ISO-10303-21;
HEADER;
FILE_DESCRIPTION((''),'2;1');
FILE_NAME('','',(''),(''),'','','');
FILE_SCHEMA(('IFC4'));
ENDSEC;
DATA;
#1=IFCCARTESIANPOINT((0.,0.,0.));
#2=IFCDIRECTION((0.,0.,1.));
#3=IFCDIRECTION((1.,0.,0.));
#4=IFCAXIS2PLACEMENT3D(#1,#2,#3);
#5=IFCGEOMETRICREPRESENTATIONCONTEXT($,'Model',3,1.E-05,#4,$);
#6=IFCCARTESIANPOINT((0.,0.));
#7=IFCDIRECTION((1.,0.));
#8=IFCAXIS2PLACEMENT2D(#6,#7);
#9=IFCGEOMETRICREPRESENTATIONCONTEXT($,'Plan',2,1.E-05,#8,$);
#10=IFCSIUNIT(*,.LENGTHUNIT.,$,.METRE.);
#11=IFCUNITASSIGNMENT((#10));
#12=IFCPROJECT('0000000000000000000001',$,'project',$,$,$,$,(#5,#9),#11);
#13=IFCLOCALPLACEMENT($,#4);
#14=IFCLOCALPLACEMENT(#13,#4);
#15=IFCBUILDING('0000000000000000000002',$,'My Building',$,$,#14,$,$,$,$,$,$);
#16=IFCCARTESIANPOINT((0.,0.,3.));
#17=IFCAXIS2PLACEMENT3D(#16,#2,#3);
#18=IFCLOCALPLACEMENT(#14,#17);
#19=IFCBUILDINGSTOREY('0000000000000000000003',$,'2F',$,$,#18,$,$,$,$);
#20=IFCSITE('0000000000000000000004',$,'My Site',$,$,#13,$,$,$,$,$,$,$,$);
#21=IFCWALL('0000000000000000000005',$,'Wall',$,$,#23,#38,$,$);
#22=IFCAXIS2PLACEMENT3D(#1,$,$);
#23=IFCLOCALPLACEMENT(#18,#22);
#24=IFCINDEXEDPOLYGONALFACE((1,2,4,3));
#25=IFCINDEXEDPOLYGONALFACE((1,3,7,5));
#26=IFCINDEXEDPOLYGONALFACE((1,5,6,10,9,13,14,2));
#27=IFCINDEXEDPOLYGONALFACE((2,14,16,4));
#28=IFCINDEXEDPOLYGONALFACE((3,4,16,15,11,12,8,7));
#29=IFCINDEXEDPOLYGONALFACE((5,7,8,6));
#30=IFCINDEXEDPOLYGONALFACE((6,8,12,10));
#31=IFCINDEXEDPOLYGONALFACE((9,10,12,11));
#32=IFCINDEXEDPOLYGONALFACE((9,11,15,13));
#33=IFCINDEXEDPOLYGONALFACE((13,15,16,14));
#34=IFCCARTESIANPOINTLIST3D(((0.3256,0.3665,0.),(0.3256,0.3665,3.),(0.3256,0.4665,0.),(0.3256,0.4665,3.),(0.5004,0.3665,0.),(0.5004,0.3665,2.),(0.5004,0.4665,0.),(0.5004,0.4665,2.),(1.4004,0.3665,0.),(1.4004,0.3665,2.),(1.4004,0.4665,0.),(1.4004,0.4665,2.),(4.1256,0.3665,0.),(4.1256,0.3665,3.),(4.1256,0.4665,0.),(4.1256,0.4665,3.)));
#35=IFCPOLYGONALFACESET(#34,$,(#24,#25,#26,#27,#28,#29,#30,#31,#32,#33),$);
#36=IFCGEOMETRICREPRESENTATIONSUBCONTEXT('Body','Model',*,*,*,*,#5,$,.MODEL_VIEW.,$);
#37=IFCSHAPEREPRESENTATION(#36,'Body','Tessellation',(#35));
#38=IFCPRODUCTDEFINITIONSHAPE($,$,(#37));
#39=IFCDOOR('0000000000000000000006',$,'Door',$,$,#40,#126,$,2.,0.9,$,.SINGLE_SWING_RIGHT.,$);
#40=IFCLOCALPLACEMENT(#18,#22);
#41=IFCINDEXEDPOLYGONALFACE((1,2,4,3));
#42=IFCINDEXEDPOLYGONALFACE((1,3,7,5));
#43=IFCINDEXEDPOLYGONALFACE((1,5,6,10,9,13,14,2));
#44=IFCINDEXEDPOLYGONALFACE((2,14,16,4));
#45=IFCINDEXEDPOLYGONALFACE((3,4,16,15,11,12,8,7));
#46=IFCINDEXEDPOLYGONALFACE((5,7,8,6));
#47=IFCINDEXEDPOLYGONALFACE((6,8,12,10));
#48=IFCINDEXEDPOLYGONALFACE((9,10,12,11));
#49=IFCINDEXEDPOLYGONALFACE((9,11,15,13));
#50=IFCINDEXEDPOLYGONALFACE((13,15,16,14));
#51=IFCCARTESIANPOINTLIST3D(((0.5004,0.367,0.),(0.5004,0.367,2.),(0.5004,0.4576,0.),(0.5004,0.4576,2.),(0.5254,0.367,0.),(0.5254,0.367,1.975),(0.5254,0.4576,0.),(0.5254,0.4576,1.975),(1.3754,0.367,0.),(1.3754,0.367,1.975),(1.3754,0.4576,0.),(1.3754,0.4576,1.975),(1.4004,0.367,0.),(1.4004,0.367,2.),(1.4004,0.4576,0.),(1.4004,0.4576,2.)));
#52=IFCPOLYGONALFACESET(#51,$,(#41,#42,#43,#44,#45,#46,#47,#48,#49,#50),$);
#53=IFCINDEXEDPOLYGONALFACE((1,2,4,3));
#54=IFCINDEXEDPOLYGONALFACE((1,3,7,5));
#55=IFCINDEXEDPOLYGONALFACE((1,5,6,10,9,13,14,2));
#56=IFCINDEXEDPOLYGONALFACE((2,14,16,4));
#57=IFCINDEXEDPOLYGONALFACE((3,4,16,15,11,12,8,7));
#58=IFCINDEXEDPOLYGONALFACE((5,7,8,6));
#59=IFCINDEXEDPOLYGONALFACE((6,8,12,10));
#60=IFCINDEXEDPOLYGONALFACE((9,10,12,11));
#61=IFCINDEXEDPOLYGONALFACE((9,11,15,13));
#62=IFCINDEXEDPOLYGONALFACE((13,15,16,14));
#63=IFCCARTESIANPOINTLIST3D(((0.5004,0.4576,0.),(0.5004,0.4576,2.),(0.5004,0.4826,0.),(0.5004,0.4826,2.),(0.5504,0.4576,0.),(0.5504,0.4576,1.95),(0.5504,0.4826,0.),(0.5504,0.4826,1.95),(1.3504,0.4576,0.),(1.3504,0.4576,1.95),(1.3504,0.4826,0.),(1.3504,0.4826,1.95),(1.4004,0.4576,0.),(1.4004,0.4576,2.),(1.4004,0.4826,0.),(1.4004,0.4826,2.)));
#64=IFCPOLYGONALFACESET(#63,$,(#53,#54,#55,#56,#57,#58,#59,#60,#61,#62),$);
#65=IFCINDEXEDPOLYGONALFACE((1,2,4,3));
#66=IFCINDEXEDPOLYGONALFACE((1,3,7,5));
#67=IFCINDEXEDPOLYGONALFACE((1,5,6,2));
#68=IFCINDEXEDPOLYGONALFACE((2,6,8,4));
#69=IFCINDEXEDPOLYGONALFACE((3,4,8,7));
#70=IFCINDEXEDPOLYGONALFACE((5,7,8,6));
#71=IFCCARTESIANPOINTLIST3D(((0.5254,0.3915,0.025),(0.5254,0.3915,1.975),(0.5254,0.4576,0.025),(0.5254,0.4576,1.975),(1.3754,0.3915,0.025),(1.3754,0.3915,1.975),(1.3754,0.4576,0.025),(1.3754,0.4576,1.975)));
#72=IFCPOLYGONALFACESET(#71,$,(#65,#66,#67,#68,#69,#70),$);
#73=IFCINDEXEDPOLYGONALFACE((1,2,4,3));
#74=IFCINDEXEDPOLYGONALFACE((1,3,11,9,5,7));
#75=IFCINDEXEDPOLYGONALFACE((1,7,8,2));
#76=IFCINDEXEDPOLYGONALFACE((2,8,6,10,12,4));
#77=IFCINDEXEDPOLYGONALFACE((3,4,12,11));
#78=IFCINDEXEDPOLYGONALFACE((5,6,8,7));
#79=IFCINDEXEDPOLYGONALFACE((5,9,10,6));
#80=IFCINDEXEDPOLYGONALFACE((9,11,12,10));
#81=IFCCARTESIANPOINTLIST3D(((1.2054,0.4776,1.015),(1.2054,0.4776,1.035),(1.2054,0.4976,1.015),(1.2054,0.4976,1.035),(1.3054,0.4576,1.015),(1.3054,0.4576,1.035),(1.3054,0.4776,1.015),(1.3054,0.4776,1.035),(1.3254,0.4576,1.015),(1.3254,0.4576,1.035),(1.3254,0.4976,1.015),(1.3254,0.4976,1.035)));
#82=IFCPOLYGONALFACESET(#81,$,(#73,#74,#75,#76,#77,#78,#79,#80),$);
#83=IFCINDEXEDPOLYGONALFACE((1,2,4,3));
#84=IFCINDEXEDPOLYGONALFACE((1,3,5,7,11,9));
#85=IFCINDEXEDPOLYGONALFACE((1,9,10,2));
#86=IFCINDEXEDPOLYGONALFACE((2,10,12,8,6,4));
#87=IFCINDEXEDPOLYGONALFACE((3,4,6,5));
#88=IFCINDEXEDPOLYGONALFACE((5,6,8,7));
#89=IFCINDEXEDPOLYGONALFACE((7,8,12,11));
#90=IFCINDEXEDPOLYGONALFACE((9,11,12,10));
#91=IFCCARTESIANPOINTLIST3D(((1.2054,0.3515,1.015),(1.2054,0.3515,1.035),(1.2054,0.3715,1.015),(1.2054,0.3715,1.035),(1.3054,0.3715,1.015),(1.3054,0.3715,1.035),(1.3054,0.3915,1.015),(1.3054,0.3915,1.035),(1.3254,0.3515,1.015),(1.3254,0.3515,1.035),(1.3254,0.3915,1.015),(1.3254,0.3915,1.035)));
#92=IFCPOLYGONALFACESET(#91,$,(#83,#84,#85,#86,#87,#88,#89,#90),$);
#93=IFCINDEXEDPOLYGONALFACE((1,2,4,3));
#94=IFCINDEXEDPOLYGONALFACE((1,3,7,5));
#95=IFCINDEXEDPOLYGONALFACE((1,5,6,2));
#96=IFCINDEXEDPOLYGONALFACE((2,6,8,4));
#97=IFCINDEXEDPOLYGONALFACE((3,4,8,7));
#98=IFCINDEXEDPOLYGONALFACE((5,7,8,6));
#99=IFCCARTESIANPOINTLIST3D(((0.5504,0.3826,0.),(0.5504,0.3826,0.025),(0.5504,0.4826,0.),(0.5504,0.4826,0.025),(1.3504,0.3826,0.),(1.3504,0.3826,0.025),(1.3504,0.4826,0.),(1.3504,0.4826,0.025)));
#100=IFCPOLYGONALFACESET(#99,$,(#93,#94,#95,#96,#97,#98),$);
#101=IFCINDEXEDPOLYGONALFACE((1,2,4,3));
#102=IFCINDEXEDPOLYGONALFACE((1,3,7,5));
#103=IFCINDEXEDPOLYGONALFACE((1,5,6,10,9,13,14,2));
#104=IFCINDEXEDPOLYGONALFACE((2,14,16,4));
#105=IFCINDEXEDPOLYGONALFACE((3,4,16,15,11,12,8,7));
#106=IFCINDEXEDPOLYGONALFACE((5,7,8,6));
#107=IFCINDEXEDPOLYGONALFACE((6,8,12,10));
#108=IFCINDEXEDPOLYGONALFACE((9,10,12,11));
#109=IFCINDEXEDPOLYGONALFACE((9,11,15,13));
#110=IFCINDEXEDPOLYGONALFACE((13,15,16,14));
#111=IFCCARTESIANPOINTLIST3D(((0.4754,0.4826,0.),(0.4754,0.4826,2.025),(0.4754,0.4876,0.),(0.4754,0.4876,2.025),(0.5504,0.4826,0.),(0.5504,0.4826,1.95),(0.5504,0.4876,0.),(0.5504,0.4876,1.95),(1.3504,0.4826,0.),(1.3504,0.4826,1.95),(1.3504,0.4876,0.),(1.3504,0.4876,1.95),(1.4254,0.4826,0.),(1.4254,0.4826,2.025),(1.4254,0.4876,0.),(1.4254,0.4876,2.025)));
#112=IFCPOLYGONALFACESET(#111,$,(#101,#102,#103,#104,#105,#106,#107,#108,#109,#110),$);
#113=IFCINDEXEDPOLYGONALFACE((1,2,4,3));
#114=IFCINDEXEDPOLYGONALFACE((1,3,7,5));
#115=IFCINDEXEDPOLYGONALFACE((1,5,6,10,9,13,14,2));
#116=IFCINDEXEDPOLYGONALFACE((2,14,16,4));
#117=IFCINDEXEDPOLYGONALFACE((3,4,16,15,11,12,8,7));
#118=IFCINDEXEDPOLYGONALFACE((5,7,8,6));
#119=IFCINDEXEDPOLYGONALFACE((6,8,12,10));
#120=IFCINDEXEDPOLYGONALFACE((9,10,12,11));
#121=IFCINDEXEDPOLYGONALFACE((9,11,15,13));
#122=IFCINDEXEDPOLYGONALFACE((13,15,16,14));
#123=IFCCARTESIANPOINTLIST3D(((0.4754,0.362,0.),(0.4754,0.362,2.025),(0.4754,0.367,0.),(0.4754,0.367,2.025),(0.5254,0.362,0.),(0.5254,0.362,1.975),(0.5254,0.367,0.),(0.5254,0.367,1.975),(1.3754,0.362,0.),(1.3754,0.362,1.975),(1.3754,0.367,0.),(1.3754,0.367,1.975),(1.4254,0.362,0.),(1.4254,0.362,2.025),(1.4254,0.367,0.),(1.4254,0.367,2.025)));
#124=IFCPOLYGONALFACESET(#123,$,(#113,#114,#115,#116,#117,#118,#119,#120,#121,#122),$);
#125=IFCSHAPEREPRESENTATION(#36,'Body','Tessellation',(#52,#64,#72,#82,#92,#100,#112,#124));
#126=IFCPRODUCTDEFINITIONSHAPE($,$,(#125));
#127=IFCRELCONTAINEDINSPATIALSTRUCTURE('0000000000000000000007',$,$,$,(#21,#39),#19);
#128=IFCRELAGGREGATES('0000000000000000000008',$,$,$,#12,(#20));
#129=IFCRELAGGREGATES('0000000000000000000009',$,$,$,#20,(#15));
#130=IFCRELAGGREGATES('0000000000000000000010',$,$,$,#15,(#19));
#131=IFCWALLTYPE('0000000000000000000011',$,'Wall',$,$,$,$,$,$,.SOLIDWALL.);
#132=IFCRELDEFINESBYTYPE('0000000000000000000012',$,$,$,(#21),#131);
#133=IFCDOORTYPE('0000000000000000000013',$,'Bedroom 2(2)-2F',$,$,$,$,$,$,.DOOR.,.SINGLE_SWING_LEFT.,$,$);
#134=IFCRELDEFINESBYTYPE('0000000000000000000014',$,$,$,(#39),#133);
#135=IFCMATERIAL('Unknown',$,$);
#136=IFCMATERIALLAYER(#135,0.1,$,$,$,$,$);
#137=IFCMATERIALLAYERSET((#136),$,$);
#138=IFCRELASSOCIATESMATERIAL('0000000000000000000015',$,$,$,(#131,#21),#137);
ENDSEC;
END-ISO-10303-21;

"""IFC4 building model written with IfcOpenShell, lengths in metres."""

from ifc_helpers import new_model, entity, si_unit, frame, origin_with_axes, origin_2d_with_axis, place, context, subcontext, project, spatial, line, indexed_curve, outline, extrude, shape, source, transform, mapped, material, layer, layer_set, layer_usage, type_object, type_shapes, element, fill, save


model = new_model("IFC4")

# Units and contexts
model_context = context("Model", 3, precision=1e-05, world=origin_with_axes())
plan_context = context("Plan", 2, precision=1e-05, world=origin_2d_with_axis())
body_context_1 = subcontext(model_context, "Body", "Model", "MODEL_VIEW")
body_context_2 = subcontext(plan_context, "Body", "Plan", "PLAN_VIEW")
ifc_project = project(units=[si_unit("LENGTHUNIT", "METRE")], contexts=[model_context, plan_context])

# Site, building, storey
site_placement = place(None, origin_with_axes())
site = spatial("IfcSite", under=ifc_project, at=site_placement, Name="My Site")
building_placement = place(site_placement, origin_with_axes())
building = spatial("IfcBuilding", under=site, at=building_placement, Name="My Building")
storey_placement = place(building_placement, frame((0.0, 0.0, 3.0), z_axis=(0.0, 0.0, 1.0), x_axis=(1.0, 0.0, 0.0)))
storey = spatial("IfcBuildingStorey", under=building, at=storey_placement, Name="2F")

# Shared definitions
ifc_material = material(Name="Unknown")

# Shared definitions
ifc_layer = layer(ifc_material, 0.1)
ifc_layer_set = layer_set([ifc_layer])
wall_type = type_object("IfcWallType", Name="Wall", PredefinedType="SOLIDWALL", material=ifc_layer_set)

# Wall, opening, door
ifc_layer_usage_1 = layer_usage(ifc_layer_set, "AXIS2", "POSITIVE", 0.0)
wall_1_placement = place(storey_placement, frame((4.1256, 0.4665, 0.0), z_axis=(0.0, 0.0, 1.0), x_axis=(-1.0, 0.0, 0.0)))
wall_1 = element("IfcWall", 1, at=wall_1_placement, inside=storey, type_object=wall_type, material=ifc_layer_usage_1, Name="Wall", context=body_context_1, shape_type="SweptSolid", body=[
    extrude(outline(indexed_curve([(0.0, 0.0), (0.0, 0.1), (3.8, 0.1), (3.8, 0.0)], segments=[line(1, 2, 3, 4, 1)])), origin_with_axes(), (0.0, 0.0, 1.0), 3.0),
])
shared_shape_1 = source(origin_with_axes(), body_context_1, "Body", "SweptSolid", [
    extrude(outline(indexed_curve([(0.0, 0.0), (0.9, 0.0), (0.9, 2.0), (0.0, 2.0)], segments=[line(1, 2, 3, 4, 1)])), frame((0.0, -0.6, 0.0), z_axis=(0.0, -1.0, 0.0), x_axis=(1.0, 0.0, 0.0)), (0.0, 0.0, -1.0), 1.2),
])
opening_1_placement = place(wall_1_placement, frame((2.7252, -0.0161, 0.0), z_axis=(0.0, 0.0, 1.0), x_axis=(1.0, 0.0, 0.0)))
opening_1 = element("IfcOpeningElement", 2, at=opening_1_placement, cuts=wall_1, PredefinedType="OPENING", context=body_context_1, shape_type="MappedRepresentation", body=[
    mapped(shared_shape_1, transform((0.0, 0.0, 0.0), x_axis=(1.0, 0.0, 0.0), y_axis=(0.0, 1.0, 0.0), z_axis=(0.0, 0.0, 1.0), scale=1.0)),
])
door_type_1 = type_object("IfcDoorType", Name="Bedroom 2(2)-2F", OperationType="SINGLE_SWING_LEFT", PredefinedType="DOOR")
shared_shape_2 = source(origin_with_axes(), body_context_1, "Body", "SweptSolid", [
    extrude(outline(indexed_curve([(0.0, 0.0), (0.0, 2.0), (0.9, 2.0), (0.9, 0.0), (0.875, 0.0), (0.875, 1.975), (0.025, 1.975), (0.025, 0.0)], segments=[line(1, 2, 3, 4, 5, 6, 7, 8, 1)])), frame((0.0, 0.025, 0.0), z_axis=(0.0, -1.0, 0.0), x_axis=(1.0, 0.0, 0.0)), (0.0, 0.0, -1.0), 0.0906),
    extrude(outline(indexed_curve([(0.0, 0.0), (0.0, 2.0), (0.9, 2.0), (0.9, 0.0), (0.85, 0.0), (0.85, 1.95), (0.05, 1.95), (0.05, 0.0)], segments=[line(1, 2, 3, 4, 5, 6, 7, 8, 1)])), frame((0.0, 0.0, 0.0), z_axis=(0.0, -1.0, 0.0), x_axis=(1.0, 0.0, 0.0)), (0.0, 0.0, -1.0), 0.025),
    extrude(outline(indexed_curve([(0.0, 0.0), (0.85, 0.0), (0.85, 0.0661), (0.0, 0.0661)], segments=[line(1, 2, 3, 4, 1)])), frame((0.025, 0.025, 0.025), z_axis=(0.0, 0.0, 1.0), x_axis=(1.0, 0.0, 0.0)), (0.0, 0.0, 1.0), 1.95),
    extrude(outline(indexed_curve([(0.0, 0.0), (0.0, -0.04), (0.12, -0.04), (0.12, -0.02), (0.02, -0.02), (0.02, 0.0)], segments=[line(1, 2, 3, 4, 5, 6, 1)])), frame((0.075, 0.025, 1.015), z_axis=(0.0, 0.0, 1.0), x_axis=(1.0, 0.0, 0.0)), (0.0, 0.0, 1.0), 0.02),
    extrude(outline(indexed_curve([(0.0, 0.0), (0.0, 0.04), (0.12, 0.04), (0.12, 0.02), (0.02, 0.02), (0.02, 0.0)], segments=[line(1, 2, 3, 4, 5, 6, 1)])), frame((0.075, 0.0911, 1.015), z_axis=(0.0, 0.0, 1.0), x_axis=(1.0, 0.0, 0.0)), (0.0, 0.0, 1.0), 0.02),
    extrude(outline(indexed_curve([(0.0, 0.0), (0.8, 0.0), (0.8, 0.1), (0.0, 0.1)], segments=[line(1, 2, 3, 4, 1)])), frame((0.05, 0.0, 0.0), z_axis=(0.0, 0.0, 1.0), x_axis=(1.0, 0.0, 0.0)), (0.0, 0.0, 1.0), 0.025),
    extrude(outline(indexed_curve([(0.0, 0.0), (0.0, 2.025), (0.95, 2.025), (0.95, 0.0), (0.875, 0.0), (0.875, 1.95), (0.075, 1.95), (0.075, 0.0)], segments=[line(1, 2, 3, 4, 5, 6, 7, 8, 1)])), frame((-0.025, -0.005, 0.0), z_axis=(0.0, -1.0, 0.0), x_axis=(1.0, 0.0, 0.0)), (0.0, 0.0, -1.0), 0.005),
    extrude(outline(indexed_curve([(0.0, 0.0), (0.0, 2.025), (0.95, 2.025), (0.95, 0.0), (0.9, 0.0), (0.9, 1.975), (0.05, 1.975), (0.05, 0.0)], segments=[line(1, 2, 3, 4, 5, 6, 7, 8, 1)])), frame((-0.025, 0.1156, 0.0), z_axis=(0.0, -1.0, 0.0), x_axis=(1.0, 0.0, 0.0)), (0.0, 0.0, -1.0), 0.005),
])
shared_shape_3 = source(origin_with_axes(), body_context_2, "Body", "Curve2D", [
    entity("IfcIndexedPolyCurve", entity("IfcCartesianPointList2D", [[0.0, 0.0], [0.0, 0.1156], [0.025, 0.1156], [0.025, 0.025], [0.05, 0.025], [0.05, 0.0]]), [entity("IfcLineIndex", [1, 2, 3, 4, 5, 6, 1])]),
    entity("IfcIndexedPolyCurve", entity("IfcCartesianPointList2D", [[0.9, 0.0], [0.9, 0.1156], [0.875, 0.1156], [0.875, 0.025], [0.85, 0.025], [0.85, 0.0]]), [entity("IfcLineIndex", [1, 2, 3, 4, 5, 6, 1])]),
    entity("IfcTrimmedCurve", entity("IfcEllipse", entity("IfcAxis2Placement2D", entity("IfcCartesianPoint", [0.8089, 0.1156]), entity("IfcDirection", [1.0, 0.0])), 0.7839, 0.85), [entity("IfcCartesianPoint", [0.8089, 0.9656])], [entity("IfcCartesianPoint", [0.025, 0.1156])], True, "CARTESIAN"),
    entity("IfcIndexedPolyCurve", entity("IfcCartesianPointList2D", [[0.875, 0.1156], [0.8089, 0.1156], [0.8089, 0.9656], [0.875, 0.9656]]), [entity("IfcLineIndex", [1, 2, 3, 4, 1])]),
])
type_shapes(door_type_1, [shared_shape_2, shared_shape_3])
door_1_placement = place(opening_1_placement, frame((0.0, 0.0, 0.0), z_axis=(0.0, 0.0, 1.0), x_axis=(1.0, 0.0, 0.0)))
door_1 = element("IfcDoor", 3, at=door_1_placement, inside=storey, type_object=door_type_1, Name="Door", OperationType="SINGLE_SWING_RIGHT", OverallHeight=2.0, OverallWidth=0.9, shapes=[
    shape(body_context_1, "Body", "MappedRepresentation", [mapped(shared_shape_2, transform((0.0, 0.0, 0.0), x_axis=(1.0, 0.0, 0.0), y_axis=(0.0, 1.0, 0.0), z_axis=(0.0, 0.0, 1.0), scale=1.0))]),
    shape(body_context_2, "Body", "MappedRepresentation", [mapped(shared_shape_3, transform((0.0, 0.0, 0.0), x_axis=(1.0, 0.0, 0.0), y_axis=(0.0, 1.0, 0.0), z_axis=(0.0, 0.0, 1.0), scale=1.0))]),
])
fill(opening_1, door_1)

save(model, "model.ifc")
